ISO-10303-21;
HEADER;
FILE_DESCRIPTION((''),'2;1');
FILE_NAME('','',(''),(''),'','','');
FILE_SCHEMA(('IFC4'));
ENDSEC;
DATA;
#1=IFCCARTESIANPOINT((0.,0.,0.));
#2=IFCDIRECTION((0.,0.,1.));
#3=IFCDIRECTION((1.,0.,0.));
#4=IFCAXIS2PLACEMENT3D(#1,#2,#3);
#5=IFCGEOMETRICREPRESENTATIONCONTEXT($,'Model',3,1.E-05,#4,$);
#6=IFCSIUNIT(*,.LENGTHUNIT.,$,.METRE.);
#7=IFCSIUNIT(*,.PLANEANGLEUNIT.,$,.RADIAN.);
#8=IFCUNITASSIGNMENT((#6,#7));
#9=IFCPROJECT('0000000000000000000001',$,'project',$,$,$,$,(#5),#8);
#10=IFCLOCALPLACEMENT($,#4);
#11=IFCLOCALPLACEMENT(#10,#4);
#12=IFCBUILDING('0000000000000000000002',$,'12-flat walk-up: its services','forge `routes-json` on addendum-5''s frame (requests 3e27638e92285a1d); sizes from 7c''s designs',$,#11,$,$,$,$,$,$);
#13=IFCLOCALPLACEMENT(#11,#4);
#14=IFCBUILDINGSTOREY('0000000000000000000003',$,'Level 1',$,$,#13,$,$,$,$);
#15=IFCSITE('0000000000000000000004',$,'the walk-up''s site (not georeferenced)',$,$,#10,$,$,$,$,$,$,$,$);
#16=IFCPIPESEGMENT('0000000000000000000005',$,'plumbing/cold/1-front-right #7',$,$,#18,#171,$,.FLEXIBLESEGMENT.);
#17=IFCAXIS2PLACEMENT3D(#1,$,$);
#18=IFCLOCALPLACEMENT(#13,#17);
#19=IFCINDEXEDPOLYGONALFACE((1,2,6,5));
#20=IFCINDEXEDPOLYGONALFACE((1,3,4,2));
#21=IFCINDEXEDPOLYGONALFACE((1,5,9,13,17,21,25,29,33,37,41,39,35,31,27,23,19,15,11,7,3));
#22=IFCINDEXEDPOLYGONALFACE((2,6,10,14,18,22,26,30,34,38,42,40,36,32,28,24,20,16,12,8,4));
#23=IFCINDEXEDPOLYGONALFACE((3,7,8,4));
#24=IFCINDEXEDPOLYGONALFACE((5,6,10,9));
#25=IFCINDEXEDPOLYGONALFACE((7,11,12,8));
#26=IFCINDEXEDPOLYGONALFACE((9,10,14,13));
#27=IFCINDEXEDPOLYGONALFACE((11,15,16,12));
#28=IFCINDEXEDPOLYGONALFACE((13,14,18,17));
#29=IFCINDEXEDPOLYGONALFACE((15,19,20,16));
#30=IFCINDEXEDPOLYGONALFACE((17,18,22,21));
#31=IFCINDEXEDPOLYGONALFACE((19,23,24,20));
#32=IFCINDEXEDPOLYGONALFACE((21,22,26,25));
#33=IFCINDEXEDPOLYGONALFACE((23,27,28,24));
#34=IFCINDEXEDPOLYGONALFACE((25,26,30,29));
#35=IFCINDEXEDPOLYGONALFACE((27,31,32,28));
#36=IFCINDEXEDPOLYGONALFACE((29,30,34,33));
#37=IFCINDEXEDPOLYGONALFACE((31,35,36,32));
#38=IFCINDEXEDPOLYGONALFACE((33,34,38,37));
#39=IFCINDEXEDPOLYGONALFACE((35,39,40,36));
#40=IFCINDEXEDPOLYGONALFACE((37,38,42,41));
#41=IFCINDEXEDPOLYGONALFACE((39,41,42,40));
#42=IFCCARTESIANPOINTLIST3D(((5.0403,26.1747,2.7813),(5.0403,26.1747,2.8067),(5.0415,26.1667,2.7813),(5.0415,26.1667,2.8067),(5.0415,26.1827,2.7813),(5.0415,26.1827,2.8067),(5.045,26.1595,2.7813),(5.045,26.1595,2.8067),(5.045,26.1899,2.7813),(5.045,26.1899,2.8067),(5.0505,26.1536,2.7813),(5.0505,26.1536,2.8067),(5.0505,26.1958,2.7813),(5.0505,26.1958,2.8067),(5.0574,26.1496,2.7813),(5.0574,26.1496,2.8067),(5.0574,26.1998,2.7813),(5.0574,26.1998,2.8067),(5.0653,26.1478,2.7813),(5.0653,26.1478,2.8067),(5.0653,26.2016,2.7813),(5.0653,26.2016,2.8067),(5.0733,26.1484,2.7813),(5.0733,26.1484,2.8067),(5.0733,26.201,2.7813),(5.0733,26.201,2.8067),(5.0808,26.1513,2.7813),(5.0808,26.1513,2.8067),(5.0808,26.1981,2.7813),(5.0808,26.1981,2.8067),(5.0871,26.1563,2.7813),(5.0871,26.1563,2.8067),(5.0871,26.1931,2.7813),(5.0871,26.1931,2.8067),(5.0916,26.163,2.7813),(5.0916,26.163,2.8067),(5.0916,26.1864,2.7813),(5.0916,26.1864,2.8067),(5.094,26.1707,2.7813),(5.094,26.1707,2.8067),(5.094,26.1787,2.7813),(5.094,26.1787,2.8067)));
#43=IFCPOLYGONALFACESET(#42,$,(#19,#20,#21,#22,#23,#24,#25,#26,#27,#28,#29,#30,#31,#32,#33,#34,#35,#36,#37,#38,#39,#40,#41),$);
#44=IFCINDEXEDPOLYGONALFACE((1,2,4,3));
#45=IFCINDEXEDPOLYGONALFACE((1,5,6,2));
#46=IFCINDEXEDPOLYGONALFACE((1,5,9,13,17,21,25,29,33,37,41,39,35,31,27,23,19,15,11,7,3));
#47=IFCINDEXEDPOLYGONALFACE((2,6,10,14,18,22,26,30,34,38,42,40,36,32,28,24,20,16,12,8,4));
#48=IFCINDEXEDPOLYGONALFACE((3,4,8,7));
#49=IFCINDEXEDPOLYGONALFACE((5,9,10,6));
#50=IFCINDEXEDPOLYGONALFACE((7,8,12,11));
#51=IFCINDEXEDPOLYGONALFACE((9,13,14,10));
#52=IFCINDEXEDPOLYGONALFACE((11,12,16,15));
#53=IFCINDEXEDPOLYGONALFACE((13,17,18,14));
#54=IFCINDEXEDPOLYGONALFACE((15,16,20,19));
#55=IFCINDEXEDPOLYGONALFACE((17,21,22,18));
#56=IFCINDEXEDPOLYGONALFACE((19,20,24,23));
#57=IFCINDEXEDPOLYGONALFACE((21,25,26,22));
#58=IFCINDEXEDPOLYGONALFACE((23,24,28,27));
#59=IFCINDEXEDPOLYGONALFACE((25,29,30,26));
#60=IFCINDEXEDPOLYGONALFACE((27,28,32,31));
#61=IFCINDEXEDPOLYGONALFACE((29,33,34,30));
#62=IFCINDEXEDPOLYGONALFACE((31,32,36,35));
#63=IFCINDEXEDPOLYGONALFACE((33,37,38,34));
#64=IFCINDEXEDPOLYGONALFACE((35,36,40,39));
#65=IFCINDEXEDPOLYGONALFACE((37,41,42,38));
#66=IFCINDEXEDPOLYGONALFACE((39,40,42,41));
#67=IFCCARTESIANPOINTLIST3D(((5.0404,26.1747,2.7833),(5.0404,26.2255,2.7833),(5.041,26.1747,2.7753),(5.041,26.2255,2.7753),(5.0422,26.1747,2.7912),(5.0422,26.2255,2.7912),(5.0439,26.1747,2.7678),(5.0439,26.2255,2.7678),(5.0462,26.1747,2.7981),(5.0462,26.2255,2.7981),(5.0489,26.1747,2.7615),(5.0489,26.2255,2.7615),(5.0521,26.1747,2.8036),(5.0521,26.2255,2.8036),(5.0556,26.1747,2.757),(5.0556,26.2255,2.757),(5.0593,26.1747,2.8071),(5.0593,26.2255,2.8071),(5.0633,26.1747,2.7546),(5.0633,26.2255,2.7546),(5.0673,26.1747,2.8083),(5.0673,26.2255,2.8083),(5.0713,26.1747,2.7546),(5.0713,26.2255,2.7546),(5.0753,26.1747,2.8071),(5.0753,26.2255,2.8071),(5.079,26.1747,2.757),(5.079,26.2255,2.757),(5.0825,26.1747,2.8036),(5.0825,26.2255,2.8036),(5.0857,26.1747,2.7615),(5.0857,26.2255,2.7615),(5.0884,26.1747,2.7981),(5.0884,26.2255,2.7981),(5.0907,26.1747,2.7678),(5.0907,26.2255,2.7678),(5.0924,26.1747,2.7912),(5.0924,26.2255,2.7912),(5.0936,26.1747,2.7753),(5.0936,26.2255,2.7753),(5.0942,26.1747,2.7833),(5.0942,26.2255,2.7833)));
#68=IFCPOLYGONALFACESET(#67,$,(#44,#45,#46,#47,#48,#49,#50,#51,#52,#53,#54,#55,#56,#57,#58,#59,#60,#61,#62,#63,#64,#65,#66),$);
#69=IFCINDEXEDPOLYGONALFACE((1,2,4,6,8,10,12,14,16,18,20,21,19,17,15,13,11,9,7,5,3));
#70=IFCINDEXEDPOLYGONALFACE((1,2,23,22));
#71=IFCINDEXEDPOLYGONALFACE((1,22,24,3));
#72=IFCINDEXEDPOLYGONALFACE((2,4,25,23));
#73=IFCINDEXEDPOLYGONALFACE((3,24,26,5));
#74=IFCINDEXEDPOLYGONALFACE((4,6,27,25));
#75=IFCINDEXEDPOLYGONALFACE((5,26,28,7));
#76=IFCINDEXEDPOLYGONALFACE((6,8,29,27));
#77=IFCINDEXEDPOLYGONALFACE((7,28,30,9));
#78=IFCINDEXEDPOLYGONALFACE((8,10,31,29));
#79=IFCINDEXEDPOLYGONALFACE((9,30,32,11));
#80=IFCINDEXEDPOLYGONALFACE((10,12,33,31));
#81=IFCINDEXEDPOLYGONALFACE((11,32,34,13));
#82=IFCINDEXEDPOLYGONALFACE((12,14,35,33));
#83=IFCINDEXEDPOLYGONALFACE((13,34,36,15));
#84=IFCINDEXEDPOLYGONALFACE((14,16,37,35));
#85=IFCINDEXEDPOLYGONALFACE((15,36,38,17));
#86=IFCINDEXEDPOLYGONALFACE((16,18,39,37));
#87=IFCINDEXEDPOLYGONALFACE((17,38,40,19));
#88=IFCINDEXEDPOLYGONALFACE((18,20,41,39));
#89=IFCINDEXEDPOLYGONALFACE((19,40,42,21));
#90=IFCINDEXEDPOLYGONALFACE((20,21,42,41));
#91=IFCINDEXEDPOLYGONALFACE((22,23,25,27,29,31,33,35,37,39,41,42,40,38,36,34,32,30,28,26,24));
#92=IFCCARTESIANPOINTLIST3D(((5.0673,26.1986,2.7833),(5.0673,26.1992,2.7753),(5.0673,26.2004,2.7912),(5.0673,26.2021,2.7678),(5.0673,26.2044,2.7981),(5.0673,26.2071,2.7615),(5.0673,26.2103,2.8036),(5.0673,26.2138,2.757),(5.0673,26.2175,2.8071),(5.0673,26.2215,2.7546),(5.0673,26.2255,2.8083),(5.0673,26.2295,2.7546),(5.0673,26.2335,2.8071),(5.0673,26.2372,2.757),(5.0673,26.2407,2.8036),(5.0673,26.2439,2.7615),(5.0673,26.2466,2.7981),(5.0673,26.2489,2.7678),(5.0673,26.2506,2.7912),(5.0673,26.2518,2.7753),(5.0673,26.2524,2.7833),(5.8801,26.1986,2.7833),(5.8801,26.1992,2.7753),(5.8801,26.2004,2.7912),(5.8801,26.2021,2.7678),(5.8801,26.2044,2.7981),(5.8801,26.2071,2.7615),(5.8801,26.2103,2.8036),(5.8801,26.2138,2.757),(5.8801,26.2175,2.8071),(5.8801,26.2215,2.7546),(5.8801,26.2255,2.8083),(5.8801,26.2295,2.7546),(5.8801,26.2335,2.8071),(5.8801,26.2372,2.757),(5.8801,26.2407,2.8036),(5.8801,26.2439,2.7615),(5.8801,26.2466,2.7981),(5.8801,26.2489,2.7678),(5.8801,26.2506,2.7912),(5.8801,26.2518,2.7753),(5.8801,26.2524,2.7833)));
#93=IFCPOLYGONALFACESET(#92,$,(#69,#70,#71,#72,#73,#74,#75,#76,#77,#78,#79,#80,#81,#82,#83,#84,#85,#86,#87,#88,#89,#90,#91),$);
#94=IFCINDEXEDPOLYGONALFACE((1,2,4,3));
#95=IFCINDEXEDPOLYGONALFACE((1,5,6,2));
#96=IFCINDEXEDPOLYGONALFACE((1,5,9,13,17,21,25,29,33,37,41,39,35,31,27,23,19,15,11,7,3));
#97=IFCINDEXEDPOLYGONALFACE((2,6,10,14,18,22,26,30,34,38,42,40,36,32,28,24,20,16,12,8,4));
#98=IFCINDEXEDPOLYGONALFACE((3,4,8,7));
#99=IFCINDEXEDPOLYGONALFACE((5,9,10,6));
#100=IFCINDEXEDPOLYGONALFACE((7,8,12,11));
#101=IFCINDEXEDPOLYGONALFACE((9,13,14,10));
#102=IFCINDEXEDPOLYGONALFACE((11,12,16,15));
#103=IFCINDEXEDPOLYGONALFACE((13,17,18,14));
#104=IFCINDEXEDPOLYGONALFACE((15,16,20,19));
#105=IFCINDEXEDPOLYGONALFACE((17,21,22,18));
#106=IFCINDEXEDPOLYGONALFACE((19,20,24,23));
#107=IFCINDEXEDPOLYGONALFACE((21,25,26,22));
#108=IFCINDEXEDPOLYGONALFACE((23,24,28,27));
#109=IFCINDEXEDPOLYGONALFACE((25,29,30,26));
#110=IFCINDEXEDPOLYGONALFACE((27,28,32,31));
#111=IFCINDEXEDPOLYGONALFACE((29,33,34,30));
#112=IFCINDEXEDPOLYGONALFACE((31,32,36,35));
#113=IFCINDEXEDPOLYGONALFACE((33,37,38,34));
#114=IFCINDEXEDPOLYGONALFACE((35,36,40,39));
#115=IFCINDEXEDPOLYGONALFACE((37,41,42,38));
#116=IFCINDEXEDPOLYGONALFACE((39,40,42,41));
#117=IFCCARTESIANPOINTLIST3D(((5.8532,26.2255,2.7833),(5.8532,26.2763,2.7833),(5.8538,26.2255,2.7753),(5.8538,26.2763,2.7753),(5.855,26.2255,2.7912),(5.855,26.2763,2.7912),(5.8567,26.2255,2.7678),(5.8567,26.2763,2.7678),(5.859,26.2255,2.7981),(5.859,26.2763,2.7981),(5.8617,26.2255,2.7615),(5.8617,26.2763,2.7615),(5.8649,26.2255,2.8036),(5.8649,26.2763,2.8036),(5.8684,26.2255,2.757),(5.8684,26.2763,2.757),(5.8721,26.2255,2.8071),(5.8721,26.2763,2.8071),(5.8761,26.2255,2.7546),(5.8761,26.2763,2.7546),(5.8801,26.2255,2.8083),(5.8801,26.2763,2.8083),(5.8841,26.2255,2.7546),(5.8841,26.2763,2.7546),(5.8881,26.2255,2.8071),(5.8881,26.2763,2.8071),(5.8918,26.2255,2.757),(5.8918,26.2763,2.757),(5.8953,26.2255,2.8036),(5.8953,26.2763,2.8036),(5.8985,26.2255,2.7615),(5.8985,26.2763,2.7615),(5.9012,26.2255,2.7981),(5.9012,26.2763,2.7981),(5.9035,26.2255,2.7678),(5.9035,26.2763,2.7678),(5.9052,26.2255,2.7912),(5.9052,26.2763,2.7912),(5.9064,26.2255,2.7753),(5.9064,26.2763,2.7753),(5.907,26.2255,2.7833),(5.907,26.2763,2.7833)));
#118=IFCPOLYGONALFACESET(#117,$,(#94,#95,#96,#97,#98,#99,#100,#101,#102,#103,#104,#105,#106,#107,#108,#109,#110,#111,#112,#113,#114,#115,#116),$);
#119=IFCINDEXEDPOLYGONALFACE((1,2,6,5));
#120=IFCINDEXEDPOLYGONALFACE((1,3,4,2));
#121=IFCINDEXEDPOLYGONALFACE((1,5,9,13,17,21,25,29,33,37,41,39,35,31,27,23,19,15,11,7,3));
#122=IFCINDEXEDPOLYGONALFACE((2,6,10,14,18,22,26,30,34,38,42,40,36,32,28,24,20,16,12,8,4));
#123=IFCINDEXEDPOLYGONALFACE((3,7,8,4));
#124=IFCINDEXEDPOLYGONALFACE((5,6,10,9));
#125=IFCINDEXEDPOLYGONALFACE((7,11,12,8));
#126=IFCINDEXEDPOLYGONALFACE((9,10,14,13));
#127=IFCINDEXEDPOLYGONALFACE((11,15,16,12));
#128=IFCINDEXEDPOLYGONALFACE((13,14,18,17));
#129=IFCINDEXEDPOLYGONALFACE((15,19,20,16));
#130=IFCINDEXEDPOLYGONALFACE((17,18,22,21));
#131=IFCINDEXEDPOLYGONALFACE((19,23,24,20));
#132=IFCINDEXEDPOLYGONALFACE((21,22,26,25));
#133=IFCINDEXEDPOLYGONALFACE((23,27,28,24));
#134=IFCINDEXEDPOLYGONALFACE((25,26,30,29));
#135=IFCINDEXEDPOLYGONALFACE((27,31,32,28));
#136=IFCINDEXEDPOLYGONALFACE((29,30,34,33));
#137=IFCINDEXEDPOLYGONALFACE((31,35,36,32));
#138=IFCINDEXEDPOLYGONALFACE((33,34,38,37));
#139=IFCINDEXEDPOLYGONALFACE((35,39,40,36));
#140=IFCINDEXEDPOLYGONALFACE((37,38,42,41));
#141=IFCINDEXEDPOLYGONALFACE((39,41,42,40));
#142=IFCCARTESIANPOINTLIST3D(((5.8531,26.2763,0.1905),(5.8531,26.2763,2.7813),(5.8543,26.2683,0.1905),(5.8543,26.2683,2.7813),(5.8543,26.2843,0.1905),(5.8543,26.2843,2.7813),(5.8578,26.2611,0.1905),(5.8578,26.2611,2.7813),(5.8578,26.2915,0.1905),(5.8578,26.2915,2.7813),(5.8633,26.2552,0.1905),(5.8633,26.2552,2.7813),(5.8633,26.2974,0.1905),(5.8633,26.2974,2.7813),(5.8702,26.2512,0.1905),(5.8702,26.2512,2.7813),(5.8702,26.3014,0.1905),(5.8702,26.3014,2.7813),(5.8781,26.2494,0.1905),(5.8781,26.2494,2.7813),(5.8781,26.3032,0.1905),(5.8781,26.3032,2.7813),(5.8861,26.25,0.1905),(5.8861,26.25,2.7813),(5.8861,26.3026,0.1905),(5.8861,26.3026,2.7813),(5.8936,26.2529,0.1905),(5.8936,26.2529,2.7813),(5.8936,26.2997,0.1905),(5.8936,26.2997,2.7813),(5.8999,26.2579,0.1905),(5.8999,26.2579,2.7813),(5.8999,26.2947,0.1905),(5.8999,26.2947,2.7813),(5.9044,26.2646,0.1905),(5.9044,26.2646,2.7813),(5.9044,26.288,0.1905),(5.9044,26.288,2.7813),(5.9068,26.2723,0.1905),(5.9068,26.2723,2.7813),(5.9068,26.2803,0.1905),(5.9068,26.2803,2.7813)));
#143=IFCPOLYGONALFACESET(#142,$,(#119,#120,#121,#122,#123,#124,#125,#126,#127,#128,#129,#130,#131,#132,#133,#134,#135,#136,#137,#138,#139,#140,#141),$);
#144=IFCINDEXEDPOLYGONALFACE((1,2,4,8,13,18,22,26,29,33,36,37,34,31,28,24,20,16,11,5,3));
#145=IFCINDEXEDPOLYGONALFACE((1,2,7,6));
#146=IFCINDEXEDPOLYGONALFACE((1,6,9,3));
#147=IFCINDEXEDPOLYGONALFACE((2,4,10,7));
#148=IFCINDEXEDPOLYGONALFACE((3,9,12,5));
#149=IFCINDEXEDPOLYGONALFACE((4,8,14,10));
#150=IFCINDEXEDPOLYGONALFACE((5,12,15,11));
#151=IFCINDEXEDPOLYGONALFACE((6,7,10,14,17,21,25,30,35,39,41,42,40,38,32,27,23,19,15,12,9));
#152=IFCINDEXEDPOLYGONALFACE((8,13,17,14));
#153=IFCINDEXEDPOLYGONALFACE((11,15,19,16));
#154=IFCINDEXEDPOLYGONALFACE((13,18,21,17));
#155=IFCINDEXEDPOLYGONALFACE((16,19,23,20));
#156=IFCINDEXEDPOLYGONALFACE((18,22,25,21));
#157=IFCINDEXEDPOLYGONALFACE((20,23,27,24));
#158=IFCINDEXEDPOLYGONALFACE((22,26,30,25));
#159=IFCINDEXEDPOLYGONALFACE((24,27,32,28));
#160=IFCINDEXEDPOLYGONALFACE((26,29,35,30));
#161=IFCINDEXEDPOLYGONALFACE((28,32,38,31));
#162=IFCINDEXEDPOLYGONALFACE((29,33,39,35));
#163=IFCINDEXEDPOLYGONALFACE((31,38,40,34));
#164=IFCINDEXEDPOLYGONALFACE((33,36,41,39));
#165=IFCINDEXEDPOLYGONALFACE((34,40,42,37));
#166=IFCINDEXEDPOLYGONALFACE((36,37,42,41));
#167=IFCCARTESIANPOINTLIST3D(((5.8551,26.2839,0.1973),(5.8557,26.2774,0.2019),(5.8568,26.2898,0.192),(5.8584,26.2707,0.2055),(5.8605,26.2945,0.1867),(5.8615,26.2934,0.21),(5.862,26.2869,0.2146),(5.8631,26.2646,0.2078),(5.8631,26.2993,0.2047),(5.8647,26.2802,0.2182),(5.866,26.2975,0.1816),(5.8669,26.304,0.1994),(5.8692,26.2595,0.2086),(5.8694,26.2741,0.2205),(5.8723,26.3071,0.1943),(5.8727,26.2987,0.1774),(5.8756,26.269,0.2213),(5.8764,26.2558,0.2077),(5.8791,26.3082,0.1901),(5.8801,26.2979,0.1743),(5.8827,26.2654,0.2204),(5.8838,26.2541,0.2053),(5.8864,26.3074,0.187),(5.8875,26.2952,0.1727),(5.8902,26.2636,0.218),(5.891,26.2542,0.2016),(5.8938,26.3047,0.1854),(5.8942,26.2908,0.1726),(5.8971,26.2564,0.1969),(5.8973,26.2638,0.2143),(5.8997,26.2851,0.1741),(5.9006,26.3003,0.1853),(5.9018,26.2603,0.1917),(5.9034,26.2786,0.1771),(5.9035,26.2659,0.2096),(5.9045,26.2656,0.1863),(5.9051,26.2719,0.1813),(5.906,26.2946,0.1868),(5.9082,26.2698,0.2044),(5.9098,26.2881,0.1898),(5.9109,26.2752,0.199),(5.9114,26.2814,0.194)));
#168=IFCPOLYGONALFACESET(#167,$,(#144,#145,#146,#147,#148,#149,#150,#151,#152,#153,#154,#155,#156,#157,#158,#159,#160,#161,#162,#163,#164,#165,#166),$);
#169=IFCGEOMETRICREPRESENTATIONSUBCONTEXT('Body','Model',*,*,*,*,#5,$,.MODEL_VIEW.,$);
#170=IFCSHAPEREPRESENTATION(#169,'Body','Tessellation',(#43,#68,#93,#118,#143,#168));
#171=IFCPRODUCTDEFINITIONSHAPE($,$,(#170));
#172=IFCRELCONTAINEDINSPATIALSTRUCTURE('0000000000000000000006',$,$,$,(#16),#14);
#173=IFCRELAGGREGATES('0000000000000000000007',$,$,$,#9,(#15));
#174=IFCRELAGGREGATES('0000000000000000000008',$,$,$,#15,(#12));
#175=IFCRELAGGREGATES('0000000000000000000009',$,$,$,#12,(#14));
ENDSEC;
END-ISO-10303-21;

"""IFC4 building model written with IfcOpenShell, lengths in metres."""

from ifc_helpers import new_model, entity, si_unit, frame, origin_with_axes, place, context, subcontext, project, spatial, element, save


model = new_model("IFC4")

# Units and contexts
model_context = context("Model", 3, precision=1e-05, world=origin_with_axes())
body_context = subcontext(model_context, "Body", "Model", "MODEL_VIEW")
ifc_project = project(units=[si_unit("LENGTHUNIT", "METRE"), si_unit("PLANEANGLEUNIT", "RADIAN")], contexts=[model_context])

# Site, building, storey
site_placement = place(None, origin_with_axes())
site = spatial("IfcSite", under=ifc_project, at=site_placement, Name="the walk-up's site (not georeferenced)")
building_placement = place(site_placement, origin_with_axes())
building = spatial("IfcBuilding", under=site, at=building_placement, Name="12-flat walk-up: its services", Description="forge `routes-json` on addendum-5's frame (requests 3e27638e92285a1d); sizes from 7c's designs")
storey_placement = place(building_placement, origin_with_axes())
storey = spatial("IfcBuildingStorey", under=building, at=storey_placement, Name="Level 1")

# Pipe segment
pipe_segment_1_placement = place(storey_placement, frame((5.0673, 26.1747, 2.8067), z_axis=(0.0, 0.0, 1.0), x_axis=(1.0, 0.0, 0.0)))
element("IfcPipeSegment", 1, at=pipe_segment_1_placement, inside=storey, Name="plumbing/cold/1-front-right #7", PredefinedType="FLEXIBLESEGMENT", context=body_context, shape_type="AdvancedSweptSolid", body=[
    entity("IfcSweptDiskSolid", entity("IfcPolyline", [entity("IfcCartesianPoint", [0.0, 0.0, 0.0]), entity("IfcCartesianPoint", [0.0, 0.0, -0.0254])]), 0.027),
    entity("IfcSweptDiskSolid", entity("IfcPolyline", [entity("IfcCartesianPoint", [0.0, 0.0, -0.0254]), entity("IfcCartesianPoint", [0.0, 0.0508, -0.0254])]), 0.027),
    entity("IfcSweptDiskSolid", entity("IfcPolyline", [entity("IfcCartesianPoint", [0.0, 0.0508, -0.0254]), entity("IfcCartesianPoint", [0.8128, 0.0508, -0.0254])]), 0.027),
    entity("IfcSweptDiskSolid", entity("IfcPolyline", [entity("IfcCartesianPoint", [0.8128, 0.0508, -0.0254]), entity("IfcCartesianPoint", [0.8128, 0.1016, -0.0254])]), 0.027),
    entity("IfcSweptDiskSolid", entity("IfcPolyline", [entity("IfcCartesianPoint", [0.8128, 0.1016, -0.0254]), entity("IfcCartesianPoint", [0.8128, 0.1016, -2.6162])]), 0.027),
    entity("IfcSweptDiskSolid", entity("IfcPolyline", [entity("IfcCartesianPoint", [0.8128, 0.1016, -2.6162]), entity("IfcCartesianPoint", [0.8192, 0.1111, -2.6035])]), 0.027),
])

save(model, "model.ifc")
